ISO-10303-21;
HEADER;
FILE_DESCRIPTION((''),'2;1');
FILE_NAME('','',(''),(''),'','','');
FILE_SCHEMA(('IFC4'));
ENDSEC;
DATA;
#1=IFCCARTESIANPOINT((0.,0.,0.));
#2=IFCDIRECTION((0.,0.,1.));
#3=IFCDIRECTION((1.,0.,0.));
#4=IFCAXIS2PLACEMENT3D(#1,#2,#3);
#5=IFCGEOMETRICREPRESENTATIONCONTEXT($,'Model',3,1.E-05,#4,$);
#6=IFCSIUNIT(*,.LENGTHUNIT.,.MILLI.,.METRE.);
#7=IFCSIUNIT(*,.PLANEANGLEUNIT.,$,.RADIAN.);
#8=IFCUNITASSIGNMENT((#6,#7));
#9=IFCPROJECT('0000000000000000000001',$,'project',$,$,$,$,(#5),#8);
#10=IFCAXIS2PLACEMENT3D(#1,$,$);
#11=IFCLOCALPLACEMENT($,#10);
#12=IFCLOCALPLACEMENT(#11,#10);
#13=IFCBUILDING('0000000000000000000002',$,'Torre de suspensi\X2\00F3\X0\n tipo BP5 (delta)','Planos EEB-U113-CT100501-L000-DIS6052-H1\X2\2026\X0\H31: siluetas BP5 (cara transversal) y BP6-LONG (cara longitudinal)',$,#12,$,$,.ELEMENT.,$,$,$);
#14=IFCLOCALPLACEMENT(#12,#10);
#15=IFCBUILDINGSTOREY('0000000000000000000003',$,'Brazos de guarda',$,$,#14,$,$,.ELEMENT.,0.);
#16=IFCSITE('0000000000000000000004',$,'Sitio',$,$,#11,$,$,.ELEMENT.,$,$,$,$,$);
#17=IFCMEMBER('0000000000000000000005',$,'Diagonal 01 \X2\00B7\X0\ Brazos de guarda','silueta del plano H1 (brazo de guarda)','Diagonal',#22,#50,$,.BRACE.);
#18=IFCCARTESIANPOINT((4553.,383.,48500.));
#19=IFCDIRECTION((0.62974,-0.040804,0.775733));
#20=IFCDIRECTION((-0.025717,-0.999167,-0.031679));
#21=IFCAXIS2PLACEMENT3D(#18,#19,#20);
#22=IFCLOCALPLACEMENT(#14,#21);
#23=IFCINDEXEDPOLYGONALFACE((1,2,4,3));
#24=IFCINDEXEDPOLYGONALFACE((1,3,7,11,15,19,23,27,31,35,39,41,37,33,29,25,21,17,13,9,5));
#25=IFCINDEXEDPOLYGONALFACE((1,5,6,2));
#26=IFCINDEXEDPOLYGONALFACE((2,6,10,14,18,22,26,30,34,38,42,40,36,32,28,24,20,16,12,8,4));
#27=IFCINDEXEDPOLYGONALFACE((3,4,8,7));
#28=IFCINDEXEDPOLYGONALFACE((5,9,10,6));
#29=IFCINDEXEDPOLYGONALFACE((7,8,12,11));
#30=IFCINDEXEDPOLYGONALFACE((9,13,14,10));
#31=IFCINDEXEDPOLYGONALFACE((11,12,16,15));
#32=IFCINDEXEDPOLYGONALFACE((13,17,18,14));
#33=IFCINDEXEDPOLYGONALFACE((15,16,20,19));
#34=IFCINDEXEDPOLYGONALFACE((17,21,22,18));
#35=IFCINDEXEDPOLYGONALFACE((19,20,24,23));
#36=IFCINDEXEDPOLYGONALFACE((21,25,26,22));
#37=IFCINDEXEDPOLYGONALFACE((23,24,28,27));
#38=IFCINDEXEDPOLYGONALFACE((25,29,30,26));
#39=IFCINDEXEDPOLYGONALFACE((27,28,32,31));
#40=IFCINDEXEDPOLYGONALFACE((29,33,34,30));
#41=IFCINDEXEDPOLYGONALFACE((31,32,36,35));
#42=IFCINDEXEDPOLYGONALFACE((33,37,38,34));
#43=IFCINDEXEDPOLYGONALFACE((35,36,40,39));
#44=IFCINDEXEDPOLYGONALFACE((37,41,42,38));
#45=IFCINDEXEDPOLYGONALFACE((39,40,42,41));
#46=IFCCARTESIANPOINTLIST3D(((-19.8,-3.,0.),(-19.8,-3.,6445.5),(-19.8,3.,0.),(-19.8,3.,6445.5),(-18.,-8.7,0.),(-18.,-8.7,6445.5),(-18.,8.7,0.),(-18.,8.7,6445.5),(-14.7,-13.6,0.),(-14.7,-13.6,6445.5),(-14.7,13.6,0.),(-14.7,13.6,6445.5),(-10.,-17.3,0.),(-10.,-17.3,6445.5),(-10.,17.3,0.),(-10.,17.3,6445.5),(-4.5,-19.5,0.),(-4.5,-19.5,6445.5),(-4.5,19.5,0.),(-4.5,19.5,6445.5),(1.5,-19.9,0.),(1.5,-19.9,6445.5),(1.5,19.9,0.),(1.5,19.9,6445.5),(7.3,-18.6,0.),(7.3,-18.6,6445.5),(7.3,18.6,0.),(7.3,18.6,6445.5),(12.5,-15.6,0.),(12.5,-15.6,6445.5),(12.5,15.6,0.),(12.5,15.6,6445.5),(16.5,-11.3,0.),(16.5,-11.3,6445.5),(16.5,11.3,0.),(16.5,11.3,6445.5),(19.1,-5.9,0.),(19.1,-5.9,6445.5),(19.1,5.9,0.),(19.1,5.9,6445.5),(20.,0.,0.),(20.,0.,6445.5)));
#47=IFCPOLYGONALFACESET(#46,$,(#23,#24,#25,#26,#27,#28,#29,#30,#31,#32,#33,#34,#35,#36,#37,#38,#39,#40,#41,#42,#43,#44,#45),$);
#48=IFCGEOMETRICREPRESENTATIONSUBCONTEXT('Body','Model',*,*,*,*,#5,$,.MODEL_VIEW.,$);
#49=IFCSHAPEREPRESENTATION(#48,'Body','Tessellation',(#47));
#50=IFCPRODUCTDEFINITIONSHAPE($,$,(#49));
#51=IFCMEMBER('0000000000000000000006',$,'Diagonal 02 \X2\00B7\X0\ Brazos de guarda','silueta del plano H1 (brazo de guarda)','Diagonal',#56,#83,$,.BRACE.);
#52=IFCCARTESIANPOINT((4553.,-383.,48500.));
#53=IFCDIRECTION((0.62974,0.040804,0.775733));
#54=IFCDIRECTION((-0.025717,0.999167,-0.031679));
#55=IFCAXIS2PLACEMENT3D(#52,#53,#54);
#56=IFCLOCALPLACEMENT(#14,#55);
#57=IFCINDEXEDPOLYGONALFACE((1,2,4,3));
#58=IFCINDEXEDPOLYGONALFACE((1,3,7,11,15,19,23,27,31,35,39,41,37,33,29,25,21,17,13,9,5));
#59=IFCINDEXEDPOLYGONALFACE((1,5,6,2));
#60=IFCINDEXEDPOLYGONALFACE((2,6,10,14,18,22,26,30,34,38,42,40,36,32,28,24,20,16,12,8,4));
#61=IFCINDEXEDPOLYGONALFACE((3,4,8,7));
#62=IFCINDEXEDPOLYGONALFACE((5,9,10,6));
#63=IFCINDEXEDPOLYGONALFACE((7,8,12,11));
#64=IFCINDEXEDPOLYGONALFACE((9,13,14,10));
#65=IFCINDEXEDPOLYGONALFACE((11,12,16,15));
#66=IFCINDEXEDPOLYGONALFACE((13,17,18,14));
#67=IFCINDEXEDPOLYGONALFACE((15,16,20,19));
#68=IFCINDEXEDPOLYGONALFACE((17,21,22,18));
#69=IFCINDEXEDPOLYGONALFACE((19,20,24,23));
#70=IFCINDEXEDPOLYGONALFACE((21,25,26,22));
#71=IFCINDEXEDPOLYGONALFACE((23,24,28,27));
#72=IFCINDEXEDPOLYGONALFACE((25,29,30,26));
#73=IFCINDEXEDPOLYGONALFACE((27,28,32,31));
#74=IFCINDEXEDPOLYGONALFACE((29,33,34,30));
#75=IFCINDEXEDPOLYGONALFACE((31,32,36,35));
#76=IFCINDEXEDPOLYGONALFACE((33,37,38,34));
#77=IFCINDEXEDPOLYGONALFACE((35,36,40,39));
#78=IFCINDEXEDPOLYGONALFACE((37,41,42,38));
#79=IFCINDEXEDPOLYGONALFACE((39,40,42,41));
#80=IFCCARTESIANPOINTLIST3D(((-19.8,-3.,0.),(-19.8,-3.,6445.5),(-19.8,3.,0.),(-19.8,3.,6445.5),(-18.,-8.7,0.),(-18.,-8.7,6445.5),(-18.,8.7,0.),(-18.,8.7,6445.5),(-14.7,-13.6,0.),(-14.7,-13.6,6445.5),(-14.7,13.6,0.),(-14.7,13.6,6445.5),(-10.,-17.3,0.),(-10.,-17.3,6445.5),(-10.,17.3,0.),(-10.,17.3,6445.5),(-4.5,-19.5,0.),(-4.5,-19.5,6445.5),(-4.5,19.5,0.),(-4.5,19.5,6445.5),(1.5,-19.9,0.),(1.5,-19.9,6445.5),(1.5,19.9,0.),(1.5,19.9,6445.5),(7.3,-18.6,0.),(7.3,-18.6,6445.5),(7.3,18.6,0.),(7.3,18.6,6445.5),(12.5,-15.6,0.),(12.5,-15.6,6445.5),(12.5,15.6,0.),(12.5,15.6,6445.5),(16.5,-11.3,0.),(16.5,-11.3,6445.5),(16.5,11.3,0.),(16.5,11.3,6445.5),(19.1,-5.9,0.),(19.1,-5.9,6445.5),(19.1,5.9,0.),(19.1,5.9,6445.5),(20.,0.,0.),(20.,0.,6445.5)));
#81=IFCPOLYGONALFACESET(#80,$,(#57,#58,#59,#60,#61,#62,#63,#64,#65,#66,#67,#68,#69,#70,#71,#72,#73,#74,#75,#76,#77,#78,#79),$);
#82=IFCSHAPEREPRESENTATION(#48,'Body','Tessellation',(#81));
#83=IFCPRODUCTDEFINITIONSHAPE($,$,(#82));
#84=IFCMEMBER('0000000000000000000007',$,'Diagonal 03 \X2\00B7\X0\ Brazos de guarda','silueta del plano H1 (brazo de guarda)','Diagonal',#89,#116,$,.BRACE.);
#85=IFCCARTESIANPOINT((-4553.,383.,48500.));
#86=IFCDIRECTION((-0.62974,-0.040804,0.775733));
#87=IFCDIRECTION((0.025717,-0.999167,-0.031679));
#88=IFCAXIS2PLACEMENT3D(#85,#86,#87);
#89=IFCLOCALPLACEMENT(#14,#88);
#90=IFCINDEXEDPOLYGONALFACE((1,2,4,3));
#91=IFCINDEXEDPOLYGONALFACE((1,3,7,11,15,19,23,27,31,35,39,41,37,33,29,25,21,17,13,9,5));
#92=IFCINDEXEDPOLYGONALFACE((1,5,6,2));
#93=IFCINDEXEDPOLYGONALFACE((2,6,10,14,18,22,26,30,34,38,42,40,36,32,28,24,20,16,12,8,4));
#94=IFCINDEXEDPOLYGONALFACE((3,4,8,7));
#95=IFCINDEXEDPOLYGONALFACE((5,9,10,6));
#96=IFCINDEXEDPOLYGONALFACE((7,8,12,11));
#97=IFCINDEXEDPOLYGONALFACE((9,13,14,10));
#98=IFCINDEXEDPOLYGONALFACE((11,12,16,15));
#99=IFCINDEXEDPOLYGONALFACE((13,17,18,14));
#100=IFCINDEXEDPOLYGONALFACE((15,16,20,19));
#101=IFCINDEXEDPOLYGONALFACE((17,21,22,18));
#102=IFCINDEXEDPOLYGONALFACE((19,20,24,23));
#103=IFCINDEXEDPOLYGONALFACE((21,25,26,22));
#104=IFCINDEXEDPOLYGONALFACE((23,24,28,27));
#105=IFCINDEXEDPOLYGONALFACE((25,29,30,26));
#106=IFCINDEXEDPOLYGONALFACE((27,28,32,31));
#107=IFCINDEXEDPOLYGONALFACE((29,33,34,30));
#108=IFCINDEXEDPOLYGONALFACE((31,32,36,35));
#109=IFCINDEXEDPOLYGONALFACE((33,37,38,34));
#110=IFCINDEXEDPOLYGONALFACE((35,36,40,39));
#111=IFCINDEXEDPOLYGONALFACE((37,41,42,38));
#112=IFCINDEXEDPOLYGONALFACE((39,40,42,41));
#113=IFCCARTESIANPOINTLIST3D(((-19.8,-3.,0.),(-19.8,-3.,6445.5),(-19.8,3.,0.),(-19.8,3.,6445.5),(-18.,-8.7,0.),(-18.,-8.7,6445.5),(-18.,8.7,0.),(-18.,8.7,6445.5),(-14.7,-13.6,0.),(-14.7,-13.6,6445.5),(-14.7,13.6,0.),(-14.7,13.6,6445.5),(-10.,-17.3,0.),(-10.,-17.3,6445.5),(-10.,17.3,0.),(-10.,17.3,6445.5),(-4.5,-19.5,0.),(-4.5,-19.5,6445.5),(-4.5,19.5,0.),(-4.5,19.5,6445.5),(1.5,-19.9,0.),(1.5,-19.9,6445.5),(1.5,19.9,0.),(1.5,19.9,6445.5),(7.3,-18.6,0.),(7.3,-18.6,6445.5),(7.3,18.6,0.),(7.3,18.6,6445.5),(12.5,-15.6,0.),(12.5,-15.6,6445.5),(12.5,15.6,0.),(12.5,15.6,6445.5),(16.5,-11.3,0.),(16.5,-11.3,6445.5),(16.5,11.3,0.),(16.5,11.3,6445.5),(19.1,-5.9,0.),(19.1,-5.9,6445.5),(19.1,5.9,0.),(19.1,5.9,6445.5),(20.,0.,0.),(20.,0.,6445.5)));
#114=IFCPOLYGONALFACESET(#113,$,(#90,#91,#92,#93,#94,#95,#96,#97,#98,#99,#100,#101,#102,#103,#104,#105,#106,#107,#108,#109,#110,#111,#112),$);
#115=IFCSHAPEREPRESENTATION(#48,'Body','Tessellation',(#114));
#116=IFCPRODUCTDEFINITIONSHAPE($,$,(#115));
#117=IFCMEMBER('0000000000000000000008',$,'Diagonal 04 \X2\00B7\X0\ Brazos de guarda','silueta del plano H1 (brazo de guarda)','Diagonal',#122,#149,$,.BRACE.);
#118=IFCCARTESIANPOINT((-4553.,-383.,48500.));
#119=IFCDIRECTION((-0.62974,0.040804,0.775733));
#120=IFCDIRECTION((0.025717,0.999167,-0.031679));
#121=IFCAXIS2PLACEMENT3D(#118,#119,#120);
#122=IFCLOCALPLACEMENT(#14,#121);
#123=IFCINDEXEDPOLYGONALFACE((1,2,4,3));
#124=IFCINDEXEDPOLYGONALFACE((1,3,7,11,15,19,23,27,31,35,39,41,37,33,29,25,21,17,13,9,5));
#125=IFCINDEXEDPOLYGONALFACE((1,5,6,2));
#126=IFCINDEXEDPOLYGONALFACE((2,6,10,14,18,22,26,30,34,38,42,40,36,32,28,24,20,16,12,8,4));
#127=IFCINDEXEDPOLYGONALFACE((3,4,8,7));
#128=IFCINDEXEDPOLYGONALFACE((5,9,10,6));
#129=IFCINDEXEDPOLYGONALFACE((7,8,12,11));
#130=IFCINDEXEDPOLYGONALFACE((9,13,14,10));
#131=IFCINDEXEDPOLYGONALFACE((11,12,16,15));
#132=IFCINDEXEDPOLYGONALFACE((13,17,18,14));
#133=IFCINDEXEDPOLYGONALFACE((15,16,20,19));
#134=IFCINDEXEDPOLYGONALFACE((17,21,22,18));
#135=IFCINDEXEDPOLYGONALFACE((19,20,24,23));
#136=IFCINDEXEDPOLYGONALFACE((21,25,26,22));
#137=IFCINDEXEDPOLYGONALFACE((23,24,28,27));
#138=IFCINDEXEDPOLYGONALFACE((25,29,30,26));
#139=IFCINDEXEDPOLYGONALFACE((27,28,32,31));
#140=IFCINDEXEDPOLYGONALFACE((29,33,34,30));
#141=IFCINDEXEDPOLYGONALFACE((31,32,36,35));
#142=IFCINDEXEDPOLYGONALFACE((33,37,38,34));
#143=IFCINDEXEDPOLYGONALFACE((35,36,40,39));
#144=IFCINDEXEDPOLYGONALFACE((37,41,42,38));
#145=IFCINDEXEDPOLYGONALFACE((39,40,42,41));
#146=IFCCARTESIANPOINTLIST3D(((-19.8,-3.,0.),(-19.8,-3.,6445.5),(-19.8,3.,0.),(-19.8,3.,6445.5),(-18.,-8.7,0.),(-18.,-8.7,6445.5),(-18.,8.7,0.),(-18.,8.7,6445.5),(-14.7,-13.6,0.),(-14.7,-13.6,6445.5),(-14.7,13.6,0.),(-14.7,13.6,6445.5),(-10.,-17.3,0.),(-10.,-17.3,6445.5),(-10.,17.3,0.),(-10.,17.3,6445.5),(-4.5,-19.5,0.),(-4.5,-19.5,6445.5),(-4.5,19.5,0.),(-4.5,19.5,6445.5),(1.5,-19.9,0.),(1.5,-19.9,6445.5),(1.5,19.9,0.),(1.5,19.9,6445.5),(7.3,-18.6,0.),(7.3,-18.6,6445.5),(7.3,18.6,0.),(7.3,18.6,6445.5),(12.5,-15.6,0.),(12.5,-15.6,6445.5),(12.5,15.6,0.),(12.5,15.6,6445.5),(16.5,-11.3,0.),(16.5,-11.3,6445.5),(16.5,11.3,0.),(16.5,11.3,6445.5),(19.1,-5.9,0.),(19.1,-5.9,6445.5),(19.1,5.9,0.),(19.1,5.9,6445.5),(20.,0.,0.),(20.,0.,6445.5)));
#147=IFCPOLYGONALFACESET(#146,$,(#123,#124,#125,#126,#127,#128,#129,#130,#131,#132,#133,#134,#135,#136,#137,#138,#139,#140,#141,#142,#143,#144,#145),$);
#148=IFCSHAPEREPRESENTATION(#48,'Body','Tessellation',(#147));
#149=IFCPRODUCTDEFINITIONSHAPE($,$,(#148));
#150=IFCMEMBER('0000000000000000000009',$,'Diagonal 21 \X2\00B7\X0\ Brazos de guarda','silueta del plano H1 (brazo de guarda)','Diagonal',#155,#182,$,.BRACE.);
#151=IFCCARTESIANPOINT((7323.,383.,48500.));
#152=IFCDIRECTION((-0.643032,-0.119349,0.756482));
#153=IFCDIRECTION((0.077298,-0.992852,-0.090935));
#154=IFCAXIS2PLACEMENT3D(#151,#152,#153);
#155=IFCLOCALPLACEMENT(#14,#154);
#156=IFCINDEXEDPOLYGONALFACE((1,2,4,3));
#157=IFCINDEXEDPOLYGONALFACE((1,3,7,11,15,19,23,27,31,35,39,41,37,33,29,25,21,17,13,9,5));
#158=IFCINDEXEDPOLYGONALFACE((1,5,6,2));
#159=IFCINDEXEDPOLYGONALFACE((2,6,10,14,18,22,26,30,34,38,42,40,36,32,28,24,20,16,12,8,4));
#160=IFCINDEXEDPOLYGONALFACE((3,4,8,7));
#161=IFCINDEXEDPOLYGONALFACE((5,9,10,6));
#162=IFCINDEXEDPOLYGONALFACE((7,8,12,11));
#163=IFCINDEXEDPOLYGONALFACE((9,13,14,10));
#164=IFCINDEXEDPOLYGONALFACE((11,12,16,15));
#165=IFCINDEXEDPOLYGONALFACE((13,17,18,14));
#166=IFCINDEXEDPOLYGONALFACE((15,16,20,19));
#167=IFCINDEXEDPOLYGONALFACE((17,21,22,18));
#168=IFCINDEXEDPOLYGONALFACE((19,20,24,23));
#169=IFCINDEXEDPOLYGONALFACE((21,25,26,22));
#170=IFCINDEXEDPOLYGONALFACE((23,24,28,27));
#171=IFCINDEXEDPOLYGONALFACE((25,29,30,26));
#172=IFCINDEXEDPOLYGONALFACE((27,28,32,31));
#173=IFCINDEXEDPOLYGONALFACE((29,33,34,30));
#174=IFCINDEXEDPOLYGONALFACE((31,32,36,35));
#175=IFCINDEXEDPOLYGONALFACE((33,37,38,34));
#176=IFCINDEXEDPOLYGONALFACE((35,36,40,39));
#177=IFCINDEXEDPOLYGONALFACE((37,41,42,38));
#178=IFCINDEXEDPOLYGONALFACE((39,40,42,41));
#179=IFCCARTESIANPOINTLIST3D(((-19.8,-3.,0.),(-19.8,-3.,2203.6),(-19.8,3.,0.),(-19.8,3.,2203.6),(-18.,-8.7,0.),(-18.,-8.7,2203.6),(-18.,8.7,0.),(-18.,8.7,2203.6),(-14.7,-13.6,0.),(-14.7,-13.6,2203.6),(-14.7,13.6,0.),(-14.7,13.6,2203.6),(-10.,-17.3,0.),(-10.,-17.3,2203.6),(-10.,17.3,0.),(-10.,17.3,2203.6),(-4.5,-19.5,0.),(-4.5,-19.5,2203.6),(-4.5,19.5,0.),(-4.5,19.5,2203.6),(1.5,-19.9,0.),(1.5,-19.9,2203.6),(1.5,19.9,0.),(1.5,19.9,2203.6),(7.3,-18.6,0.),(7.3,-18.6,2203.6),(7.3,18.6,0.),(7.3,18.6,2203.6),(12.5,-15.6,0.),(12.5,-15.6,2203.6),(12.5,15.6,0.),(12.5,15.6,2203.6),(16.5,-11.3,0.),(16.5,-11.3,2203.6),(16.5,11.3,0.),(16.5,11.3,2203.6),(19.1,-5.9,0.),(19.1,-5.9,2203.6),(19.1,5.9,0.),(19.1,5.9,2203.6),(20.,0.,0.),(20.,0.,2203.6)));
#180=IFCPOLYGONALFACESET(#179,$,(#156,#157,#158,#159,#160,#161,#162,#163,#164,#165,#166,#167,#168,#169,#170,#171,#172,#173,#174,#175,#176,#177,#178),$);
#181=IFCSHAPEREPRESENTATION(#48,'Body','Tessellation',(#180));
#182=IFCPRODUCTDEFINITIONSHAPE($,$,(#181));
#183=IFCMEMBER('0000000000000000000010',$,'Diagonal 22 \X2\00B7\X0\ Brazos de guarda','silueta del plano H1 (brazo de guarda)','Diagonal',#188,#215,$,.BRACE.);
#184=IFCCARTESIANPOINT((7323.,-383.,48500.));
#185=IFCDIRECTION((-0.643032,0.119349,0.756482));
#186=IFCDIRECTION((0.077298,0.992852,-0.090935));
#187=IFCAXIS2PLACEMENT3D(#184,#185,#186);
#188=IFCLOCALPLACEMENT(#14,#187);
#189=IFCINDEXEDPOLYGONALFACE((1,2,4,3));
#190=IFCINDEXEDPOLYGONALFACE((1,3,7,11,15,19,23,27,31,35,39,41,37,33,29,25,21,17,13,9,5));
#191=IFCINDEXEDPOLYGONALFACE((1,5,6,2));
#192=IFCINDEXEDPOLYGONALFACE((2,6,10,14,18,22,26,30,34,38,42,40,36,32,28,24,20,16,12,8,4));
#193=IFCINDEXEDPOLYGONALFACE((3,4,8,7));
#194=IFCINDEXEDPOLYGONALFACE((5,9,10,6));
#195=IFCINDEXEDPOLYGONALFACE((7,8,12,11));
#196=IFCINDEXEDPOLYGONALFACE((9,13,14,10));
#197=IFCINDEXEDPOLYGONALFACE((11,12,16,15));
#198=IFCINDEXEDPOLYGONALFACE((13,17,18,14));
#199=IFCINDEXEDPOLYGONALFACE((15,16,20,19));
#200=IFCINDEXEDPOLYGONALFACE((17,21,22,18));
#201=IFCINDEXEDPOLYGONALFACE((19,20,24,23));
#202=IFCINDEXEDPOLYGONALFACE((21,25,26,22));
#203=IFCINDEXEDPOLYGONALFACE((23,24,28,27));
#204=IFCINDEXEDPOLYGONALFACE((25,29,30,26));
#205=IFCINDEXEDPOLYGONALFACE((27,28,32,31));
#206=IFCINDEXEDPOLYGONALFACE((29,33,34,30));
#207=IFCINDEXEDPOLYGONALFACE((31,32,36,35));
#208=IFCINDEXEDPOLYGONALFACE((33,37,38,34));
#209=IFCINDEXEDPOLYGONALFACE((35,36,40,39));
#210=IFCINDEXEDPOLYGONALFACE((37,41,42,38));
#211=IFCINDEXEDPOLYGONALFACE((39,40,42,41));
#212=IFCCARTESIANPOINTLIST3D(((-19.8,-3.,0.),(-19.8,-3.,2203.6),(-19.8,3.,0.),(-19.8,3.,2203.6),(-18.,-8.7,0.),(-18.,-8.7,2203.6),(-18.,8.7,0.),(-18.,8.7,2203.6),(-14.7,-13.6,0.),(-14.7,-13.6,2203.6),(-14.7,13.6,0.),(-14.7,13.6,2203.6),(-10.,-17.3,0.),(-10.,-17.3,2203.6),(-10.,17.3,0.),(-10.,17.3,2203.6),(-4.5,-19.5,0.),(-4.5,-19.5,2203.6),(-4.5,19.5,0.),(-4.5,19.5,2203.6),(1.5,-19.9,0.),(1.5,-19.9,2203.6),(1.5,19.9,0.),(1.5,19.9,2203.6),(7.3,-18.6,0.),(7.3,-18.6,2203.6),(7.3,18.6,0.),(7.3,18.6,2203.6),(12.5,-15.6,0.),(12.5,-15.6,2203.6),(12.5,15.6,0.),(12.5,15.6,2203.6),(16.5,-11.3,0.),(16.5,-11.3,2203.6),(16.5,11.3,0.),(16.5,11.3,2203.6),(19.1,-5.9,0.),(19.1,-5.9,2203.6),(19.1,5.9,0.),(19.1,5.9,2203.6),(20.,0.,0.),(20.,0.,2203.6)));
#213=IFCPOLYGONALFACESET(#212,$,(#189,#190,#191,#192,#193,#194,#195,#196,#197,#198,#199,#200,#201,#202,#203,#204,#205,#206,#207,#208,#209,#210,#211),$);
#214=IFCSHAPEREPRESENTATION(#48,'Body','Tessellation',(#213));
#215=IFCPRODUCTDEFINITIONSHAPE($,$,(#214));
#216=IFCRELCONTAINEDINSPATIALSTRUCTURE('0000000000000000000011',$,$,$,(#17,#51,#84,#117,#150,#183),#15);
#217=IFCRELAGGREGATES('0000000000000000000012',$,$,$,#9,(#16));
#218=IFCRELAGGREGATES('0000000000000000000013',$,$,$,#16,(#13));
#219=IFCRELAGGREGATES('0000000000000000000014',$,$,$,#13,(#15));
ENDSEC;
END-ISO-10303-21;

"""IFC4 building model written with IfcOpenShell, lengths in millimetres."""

from ifc_helpers import new_model, si_unit, frame, origin, origin_with_axes, place, context, subcontext, project, spatial, circle, extrude, element, save


model = new_model("IFC4")

# Units and contexts
model_context = context("Model", 3, precision=1e-05, world=origin_with_axes())
body_context = subcontext(model_context, "Body", "Model", "MODEL_VIEW")
ifc_project = project(units=[si_unit("LENGTHUNIT", "METRE", prefix="MILLI"), si_unit("PLANEANGLEUNIT", "RADIAN")], contexts=[model_context])

# Site, building, storey
site_placement = place(None, origin())
site = spatial("IfcSite", under=ifc_project, at=site_placement, Name="Sitio", CompositionType="ELEMENT")
building_placement = place(site_placement, origin())
building = spatial("IfcBuilding", under=site, at=building_placement, Name="Torre de suspensión tipo BP5 (delta)", Description="Planos EEB-U113-CT100501-L000-DIS6052-H1…H31: siluetas BP5 (cara transversal) y BP6-LONG (cara longitudinal)", CompositionType="ELEMENT")
storey_placement = place(building_placement, origin())
storey = spatial("IfcBuildingStorey", under=building, at=storey_placement, Name="Brazos de guarda", CompositionType="ELEMENT", Elevation=0.0)

# Members
for number, where, z_axis, x_axis, name in (
    (1, (4553.0, 383.0, 48500.0), (0.62974, -0.040804, 0.775733), (-0.025717, -0.999167, -0.031679), "Diagonal 01 · Brazos de guarda"),
    (2, (4553.0, -383.0, 48500.0), (0.62974, 0.040804, 0.775733), (-0.025717, 0.999167, -0.031679), "Diagonal 02 · Brazos de guarda"),
    (3, (-4553.0, 383.0, 48500.0), (-0.62974, -0.040804, 0.775733), (0.025717, -0.999167, -0.031679), "Diagonal 03 · Brazos de guarda"),
    (4, (-4553.0, -383.0, 48500.0), (-0.62974, 0.040804, 0.775733), (0.025717, 0.999167, -0.031679), "Diagonal 04 · Brazos de guarda"),
):
    element("IfcMember", number, at=place(storey_placement, frame(where, z_axis=z_axis, x_axis=x_axis)), inside=storey, Name=name, Description="silueta del plano H1 (brazo de guarda)", ObjectType="Diagonal", PredefinedType="BRACE", context=body_context, shape_type="SweptSolid", body=[
        extrude(circle(Radius=20.0), None, (0.0, 0.0, 1.0), 6445.5),
    ])
for number, where, z_axis, x_axis, name in (
    (5, (7323.0, 383.0, 48500.0), (-0.643032, -0.119349, 0.756482), (0.077298, -0.992852, -0.090935), "Diagonal 21 · Brazos de guarda"),
    (6, (7323.0, -383.0, 48500.0), (-0.643032, 0.119349, 0.756482), (0.077298, 0.992852, -0.090935), "Diagonal 22 · Brazos de guarda"),
):
    element("IfcMember", number, at=place(storey_placement, frame(where, z_axis=z_axis, x_axis=x_axis)), inside=storey, Name=name, Description="silueta del plano H1 (brazo de guarda)", ObjectType="Diagonal", PredefinedType="BRACE", context=body_context, shape_type="SweptSolid", body=[
        extrude(circle(Radius=20.0), None, (0.0, 0.0, 1.0), 2203.6),
    ])

save(model, "model.ifc")
